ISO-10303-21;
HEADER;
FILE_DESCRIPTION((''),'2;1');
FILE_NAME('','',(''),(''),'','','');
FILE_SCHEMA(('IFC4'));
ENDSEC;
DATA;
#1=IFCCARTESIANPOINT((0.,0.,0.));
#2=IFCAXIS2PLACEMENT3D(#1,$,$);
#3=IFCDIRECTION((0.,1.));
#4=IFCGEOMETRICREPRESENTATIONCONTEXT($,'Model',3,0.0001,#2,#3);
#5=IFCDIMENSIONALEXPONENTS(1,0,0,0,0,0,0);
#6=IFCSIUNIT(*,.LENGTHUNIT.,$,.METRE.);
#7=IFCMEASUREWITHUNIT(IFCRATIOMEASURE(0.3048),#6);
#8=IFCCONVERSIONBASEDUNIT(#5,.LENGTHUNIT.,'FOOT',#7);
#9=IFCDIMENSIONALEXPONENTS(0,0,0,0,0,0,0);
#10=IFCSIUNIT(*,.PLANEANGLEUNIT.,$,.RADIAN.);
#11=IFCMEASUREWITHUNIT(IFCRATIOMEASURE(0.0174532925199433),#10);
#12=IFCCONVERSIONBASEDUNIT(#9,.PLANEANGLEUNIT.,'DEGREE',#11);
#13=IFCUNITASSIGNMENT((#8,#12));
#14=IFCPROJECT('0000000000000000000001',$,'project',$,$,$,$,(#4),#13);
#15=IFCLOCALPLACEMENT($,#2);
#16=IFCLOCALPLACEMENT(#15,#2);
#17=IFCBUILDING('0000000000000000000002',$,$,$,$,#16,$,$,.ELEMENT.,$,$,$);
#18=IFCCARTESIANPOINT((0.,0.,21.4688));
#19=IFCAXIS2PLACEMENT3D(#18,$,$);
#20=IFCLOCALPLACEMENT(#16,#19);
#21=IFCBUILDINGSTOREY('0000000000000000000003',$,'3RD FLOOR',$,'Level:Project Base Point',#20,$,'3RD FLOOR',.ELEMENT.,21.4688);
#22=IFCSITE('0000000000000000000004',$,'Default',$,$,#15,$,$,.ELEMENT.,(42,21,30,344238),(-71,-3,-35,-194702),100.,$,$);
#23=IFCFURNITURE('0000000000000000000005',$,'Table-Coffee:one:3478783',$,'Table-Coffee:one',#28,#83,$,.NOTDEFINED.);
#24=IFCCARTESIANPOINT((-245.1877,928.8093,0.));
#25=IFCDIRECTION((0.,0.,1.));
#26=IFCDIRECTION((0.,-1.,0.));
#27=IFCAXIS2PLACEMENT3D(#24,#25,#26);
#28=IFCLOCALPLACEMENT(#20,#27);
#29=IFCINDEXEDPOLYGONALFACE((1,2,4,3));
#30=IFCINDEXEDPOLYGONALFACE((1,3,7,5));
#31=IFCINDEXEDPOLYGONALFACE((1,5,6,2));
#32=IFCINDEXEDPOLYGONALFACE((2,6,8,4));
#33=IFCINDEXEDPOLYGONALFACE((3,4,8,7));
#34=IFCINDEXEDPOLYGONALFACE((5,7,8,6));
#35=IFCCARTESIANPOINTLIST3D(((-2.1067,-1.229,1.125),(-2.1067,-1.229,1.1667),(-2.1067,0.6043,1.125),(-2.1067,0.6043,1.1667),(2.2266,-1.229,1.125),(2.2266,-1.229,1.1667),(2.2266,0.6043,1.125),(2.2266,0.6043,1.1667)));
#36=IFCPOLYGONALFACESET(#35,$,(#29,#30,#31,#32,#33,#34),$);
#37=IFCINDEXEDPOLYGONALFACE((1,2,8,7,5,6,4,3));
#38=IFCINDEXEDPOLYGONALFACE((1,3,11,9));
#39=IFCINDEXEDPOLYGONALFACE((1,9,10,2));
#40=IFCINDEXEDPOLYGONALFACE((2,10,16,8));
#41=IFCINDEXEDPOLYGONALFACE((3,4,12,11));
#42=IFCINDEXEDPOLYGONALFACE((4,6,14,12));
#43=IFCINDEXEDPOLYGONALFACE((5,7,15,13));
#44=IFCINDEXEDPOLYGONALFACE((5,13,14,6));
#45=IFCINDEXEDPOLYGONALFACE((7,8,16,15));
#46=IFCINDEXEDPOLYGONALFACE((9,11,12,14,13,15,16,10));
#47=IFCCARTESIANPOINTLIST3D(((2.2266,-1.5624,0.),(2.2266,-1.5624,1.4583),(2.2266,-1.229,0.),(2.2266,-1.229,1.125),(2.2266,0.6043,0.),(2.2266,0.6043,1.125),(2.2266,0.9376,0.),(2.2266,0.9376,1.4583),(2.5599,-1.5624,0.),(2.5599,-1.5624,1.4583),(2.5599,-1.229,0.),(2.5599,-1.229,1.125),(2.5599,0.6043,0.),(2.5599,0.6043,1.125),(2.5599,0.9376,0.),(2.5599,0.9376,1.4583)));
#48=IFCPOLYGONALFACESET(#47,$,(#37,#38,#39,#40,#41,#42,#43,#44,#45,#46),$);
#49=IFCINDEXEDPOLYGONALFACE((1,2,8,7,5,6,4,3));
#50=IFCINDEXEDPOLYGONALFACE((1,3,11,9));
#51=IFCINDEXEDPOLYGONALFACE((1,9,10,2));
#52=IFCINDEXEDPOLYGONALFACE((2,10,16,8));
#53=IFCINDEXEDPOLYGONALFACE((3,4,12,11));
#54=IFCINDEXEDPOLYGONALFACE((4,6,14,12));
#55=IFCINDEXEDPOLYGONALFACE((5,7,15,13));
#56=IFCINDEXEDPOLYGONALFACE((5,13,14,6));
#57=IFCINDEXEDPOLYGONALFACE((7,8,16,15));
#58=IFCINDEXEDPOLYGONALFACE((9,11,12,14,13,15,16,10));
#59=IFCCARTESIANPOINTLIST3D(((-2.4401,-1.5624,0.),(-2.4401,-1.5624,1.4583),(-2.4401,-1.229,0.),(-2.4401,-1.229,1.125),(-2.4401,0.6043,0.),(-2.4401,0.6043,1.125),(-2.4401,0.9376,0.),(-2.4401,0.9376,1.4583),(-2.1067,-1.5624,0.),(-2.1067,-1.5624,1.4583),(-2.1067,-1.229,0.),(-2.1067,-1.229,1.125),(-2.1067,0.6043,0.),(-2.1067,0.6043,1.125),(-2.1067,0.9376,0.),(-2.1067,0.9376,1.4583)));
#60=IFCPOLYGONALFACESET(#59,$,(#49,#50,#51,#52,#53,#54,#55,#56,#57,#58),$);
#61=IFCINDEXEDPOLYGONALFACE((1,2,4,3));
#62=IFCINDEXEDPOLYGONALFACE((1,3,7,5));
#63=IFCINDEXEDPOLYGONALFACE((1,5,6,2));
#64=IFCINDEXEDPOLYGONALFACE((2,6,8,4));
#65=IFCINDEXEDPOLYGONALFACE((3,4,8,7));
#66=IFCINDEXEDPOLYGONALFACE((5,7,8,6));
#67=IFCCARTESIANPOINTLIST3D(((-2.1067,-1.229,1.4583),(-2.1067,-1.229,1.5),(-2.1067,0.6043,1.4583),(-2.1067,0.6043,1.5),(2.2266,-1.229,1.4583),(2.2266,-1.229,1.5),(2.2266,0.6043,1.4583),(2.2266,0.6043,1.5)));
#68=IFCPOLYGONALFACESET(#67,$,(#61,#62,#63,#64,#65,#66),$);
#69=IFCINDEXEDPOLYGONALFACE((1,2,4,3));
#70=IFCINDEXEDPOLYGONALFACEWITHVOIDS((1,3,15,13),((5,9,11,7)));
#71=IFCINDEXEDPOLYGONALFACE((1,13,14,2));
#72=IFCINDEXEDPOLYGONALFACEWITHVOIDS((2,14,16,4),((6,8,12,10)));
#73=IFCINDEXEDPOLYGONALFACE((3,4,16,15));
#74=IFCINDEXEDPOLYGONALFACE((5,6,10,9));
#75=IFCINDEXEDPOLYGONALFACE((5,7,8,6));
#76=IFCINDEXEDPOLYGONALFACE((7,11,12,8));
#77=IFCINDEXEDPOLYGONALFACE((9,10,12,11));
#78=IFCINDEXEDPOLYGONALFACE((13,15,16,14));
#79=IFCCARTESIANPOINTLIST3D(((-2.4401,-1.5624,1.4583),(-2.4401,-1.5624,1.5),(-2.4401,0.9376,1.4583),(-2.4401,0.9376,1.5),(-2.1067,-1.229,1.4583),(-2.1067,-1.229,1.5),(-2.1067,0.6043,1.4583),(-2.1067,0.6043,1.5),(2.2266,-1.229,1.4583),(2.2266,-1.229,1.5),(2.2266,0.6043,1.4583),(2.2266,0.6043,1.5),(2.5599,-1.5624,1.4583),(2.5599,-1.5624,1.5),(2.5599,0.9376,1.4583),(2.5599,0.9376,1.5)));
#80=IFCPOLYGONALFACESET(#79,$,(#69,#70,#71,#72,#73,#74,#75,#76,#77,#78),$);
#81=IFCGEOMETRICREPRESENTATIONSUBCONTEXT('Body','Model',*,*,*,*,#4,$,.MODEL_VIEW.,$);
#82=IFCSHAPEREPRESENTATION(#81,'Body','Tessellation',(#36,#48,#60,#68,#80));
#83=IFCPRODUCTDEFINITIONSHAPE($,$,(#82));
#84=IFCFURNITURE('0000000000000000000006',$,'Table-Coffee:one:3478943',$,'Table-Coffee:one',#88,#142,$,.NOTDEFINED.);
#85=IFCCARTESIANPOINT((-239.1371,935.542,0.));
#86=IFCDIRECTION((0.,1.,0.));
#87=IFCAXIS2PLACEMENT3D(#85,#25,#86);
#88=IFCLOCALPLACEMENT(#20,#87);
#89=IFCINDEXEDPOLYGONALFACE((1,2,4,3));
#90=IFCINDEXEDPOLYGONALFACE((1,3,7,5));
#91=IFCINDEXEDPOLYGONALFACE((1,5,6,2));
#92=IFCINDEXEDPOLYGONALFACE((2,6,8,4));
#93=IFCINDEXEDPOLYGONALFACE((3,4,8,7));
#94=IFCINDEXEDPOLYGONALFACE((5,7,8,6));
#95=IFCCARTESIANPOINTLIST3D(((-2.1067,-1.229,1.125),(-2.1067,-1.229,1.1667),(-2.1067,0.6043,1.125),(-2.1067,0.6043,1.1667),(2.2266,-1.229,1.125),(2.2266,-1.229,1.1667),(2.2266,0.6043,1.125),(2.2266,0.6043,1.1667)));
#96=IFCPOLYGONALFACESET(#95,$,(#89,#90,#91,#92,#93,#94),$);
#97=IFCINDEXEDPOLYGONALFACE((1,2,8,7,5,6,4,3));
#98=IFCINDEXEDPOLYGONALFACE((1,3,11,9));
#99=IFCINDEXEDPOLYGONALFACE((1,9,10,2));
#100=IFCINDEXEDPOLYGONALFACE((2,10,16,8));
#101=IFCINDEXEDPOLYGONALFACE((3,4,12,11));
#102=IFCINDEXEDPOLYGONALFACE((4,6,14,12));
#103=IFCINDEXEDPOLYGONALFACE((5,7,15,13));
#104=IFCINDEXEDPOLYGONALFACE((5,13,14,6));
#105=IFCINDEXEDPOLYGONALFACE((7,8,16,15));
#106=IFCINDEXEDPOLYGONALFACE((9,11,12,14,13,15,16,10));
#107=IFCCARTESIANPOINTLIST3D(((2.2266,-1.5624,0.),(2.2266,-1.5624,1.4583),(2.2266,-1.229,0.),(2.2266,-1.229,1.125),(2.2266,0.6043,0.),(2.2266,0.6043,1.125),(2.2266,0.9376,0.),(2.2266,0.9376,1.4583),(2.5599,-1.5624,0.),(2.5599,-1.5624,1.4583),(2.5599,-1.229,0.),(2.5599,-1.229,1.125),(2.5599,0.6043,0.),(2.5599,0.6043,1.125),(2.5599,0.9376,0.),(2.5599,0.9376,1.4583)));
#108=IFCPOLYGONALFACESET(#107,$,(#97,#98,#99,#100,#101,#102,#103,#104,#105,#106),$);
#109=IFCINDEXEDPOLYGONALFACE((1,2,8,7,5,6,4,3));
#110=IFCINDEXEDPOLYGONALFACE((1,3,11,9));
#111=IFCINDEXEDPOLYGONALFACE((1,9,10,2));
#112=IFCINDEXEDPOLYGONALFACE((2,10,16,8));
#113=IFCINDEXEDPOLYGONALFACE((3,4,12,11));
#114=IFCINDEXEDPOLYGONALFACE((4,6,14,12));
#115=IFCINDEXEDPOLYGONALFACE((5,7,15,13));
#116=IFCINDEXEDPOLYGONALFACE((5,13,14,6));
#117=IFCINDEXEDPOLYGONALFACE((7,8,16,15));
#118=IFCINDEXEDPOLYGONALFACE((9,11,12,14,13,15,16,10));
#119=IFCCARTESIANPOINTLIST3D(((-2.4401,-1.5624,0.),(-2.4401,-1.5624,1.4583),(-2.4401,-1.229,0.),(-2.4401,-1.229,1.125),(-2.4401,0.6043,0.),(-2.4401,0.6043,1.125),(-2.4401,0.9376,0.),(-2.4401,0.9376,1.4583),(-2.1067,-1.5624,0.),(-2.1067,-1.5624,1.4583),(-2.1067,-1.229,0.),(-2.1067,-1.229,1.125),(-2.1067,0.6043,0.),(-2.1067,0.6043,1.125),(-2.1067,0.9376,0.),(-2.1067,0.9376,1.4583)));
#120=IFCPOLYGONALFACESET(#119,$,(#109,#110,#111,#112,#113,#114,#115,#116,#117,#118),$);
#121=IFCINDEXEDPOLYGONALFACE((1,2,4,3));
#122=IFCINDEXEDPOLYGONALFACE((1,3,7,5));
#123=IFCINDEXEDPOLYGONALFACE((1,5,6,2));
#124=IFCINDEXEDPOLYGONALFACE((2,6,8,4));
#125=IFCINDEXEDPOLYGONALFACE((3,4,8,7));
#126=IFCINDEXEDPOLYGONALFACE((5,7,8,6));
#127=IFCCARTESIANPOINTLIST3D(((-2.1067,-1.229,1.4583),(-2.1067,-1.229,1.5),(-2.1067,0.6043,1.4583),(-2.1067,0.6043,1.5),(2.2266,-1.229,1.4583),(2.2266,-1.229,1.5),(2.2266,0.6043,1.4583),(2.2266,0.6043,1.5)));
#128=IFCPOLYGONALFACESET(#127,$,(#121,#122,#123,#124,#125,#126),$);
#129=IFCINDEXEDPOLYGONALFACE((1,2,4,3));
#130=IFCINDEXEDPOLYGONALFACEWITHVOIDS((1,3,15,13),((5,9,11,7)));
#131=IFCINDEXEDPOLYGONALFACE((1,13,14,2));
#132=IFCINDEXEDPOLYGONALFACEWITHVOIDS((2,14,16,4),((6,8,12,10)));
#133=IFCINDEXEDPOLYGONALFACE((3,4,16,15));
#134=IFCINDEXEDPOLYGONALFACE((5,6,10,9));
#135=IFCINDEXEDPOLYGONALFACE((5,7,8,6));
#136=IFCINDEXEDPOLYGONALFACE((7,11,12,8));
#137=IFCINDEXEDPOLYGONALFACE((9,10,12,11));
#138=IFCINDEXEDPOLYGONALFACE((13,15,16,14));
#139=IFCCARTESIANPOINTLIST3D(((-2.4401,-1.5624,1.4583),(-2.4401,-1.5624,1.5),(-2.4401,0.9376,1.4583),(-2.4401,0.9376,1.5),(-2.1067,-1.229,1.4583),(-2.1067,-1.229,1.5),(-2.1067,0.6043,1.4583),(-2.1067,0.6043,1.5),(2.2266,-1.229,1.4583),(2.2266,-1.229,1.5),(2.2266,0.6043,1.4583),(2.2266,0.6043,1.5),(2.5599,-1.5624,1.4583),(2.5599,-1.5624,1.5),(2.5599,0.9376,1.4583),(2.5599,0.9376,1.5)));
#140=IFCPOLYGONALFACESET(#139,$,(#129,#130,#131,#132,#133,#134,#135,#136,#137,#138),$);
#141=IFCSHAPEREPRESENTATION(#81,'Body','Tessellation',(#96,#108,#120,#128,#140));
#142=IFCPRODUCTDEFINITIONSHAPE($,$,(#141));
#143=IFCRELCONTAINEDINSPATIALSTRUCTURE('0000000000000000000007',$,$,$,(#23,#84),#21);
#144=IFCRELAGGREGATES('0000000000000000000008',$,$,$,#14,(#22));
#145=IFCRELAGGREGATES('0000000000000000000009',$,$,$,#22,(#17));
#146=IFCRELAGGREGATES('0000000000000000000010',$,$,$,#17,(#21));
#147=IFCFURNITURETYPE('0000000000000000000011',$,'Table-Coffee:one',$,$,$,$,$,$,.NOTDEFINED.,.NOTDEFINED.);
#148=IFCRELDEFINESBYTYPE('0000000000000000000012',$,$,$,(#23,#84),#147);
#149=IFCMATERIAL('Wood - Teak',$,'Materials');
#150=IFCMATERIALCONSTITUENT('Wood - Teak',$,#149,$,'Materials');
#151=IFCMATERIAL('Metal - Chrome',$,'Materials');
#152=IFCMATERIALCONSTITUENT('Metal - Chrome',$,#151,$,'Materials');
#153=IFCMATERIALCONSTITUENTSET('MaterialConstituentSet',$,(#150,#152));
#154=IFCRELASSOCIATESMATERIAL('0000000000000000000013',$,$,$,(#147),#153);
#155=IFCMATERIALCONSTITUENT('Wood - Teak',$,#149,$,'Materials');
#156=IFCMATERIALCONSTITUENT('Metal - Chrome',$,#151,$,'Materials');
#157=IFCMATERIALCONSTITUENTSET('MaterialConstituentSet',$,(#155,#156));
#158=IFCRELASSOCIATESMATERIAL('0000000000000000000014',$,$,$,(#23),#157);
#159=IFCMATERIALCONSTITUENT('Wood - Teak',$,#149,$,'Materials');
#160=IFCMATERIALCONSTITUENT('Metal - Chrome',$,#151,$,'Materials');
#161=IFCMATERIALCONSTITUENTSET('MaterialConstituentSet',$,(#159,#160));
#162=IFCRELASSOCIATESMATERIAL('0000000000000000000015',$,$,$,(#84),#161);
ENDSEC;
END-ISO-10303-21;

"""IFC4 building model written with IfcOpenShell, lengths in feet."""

from ifc_helpers import new_model, entity, si_unit, converted_unit, direction, frame, origin, origin_2d_with_axis, place, context, subcontext, project, spatial, polyline, rectangle, outline, extrude, source, transform, mapped, material, constituent, constituent_set, type_object, type_shapes, element, save


model = new_model("IFC4")

# Units and contexts
model_context = context("Model", 3, precision=0.0001, world=origin(), true_north=direction((0.0, 1.0)))
body_context = subcontext(model_context, "Body", "Model", "MODEL_VIEW")
ifc_project = project(units=[converted_unit("LENGTHUNIT", "FOOT", entity("IfcRatioMeasure", 0.3048), si_unit("LENGTHUNIT", "METRE"), dimensions=[1, 0, 0, 0, 0, 0, 0]), converted_unit("PLANEANGLEUNIT", "DEGREE", entity("IfcRatioMeasure", 0.0174532925199433), si_unit("PLANEANGLEUNIT", "RADIAN"), dimensions=[0, 0, 0, 0, 0, 0, 0])], contexts=[model_context])

# Site, building, storey
site_placement = place(None, origin())
site = spatial("IfcSite", under=ifc_project, at=site_placement, Name="Default", CompositionType="ELEMENT", RefLatitude=(42, 21, 30, 344238), RefLongitude=(-71, -3, -35, -194702), RefElevation=100.0)
building_placement = place(site_placement, origin())
building = spatial("IfcBuilding", under=site, at=building_placement, CompositionType="ELEMENT")
storey_placement = place(building_placement, frame((0.0, 0.0, 21.4688)))
storey = spatial("IfcBuildingStorey", under=building, at=storey_placement, Name="3RD FLOOR", ObjectType="Level:Project Base Point", LongName="3RD FLOOR", CompositionType="ELEMENT", Elevation=21.4688)

# Furniture
ifc_material_1 = material(Name="Wood - Teak", Category="Materials")
ifc_constituent_1 = constituent(ifc_material_1, Name="Wood - Teak", Category="Materials")
ifc_material_2 = material(Name="Metal - Chrome", Category="Materials")
ifc_constituent_2 = constituent(ifc_material_2, Name="Metal - Chrome", Category="Materials")
ifc_constituent_set_1 = constituent_set(constituents=[ifc_constituent_1, ifc_constituent_2], Name="MaterialConstituentSet")
ifc_constituent_3 = constituent(ifc_material_1, Name="Wood - Teak", Category="Materials")
ifc_constituent_4 = constituent(ifc_material_2, Name="Metal - Chrome", Category="Materials")
ifc_constituent_set_2 = constituent_set(constituents=[ifc_constituent_3, ifc_constituent_4], Name="MaterialConstituentSet")
furniture_type_1 = type_object("IfcFurnitureType", Name="Table-Coffee:one", AssemblyPlace="NOTDEFINED", PredefinedType="NOTDEFINED", material=ifc_constituent_set_2)
shared_shape_1 = source(origin(), body_context, "Body", "SweptSolid", [
    extrude(rectangle(XDim=1.8333, YDim=4.3333, at=origin_2d_with_axis()), frame((0.0599, -0.3124, 1.125), z_axis=(0.0, 0.0, 1.0), x_axis=(0.0, 1.0, 0.0)), (0.0, 0.0, 1.0), 0.0417),
    extrude(outline(polyline([(-1.25, -0.6458), (-0.9167, -0.6458), (-0.9167, 0.4792), (0.9167, 0.4792), (0.9167, -0.6458), (1.25, -0.6458), (1.25, 0.8125), (-1.25, 0.8125), (-1.25, -0.6458)])), frame((2.2266, -0.3124, 0.6458), z_axis=(1.0, 0.0, 0.0), x_axis=(0.0, 1.0, 0.0)), (0.0, 0.0, 1.0), 0.3333),
    extrude(outline(polyline([(-0.8125, -1.25), (0.6458, -1.25), (0.6458, -0.9167), (-0.4792, -0.9167), (-0.4792, 0.9167), (0.6458, 0.9167), (0.6458, 1.25), (-0.8125, 1.25), (-0.8125, -1.25)])), frame((-2.4401, -0.3124, 0.6458), z_axis=(1.0, 0.0, 0.0), x_axis=(0.0, 0.0, -1.0)), (0.0, 0.0, 1.0), 0.3333),
    extrude(rectangle(XDim=1.8333, YDim=4.3333, at=origin_2d_with_axis()), frame((0.0599, -0.3124, 1.4583), z_axis=(0.0, 0.0, 1.0), x_axis=(0.0, 1.0, 0.0)), (0.0, 0.0, 1.0), 0.0417),
    extrude(outline(polyline([(-1.25, -2.5), (1.25, -2.5), (1.25, 2.5), (-1.25, 2.5), (-1.25, -2.5)]), holes=[polyline([(-0.9167, -2.1667), (-0.9167, 2.1667), (0.9167, 2.1667), (0.9167, -2.1667), (-0.9167, -2.1667)])]), frame((0.0599, -0.3124, 1.4583), z_axis=(0.0, 0.0, 1.0), x_axis=(0.0, 1.0, 0.0)), (0.0, 0.0, 1.0), 0.0417),
])
type_shapes(furniture_type_1, [shared_shape_1])
furniture_1_placement = place(storey_placement, frame((-245.1877, 928.8093, 0.0), z_axis=(0.0, 0.0, 1.0), x_axis=(0.0, -1.0, 0.0)))
element("IfcFurniture", 1, at=furniture_1_placement, inside=storey, type_object=furniture_type_1, material=ifc_constituent_set_1, Name="Table-Coffee:one:3478783", ObjectType="Table-Coffee:one", PredefinedType="NOTDEFINED", context=body_context, shape_type="MappedRepresentation", body=[
    mapped(shared_shape_1, transform((0.0, 0.0, 0.0), scale=1.0)),
])
ifc_constituent_5 = constituent(ifc_material_1, Name="Wood - Teak", Category="Materials")
ifc_constituent_6 = constituent(ifc_material_2, Name="Metal - Chrome", Category="Materials")
ifc_constituent_set_3 = constituent_set(constituents=[ifc_constituent_5, ifc_constituent_6], Name="MaterialConstituentSet")
furniture_2_placement = place(storey_placement, frame((-239.1371, 935.542, 0.0), z_axis=(0.0, 0.0, 1.0), x_axis=(0.0, 1.0, 0.0)))
element("IfcFurniture", 2, at=furniture_2_placement, inside=storey, type_object=furniture_type_1, material=ifc_constituent_set_3, Name="Table-Coffee:one:3478943", ObjectType="Table-Coffee:one", PredefinedType="NOTDEFINED", context=body_context, shape_type="MappedRepresentation", body=[
    mapped(shared_shape_1, transform((0.0, 0.0, 0.0), scale=1.0)),
])

save(model, "model.ifc")
